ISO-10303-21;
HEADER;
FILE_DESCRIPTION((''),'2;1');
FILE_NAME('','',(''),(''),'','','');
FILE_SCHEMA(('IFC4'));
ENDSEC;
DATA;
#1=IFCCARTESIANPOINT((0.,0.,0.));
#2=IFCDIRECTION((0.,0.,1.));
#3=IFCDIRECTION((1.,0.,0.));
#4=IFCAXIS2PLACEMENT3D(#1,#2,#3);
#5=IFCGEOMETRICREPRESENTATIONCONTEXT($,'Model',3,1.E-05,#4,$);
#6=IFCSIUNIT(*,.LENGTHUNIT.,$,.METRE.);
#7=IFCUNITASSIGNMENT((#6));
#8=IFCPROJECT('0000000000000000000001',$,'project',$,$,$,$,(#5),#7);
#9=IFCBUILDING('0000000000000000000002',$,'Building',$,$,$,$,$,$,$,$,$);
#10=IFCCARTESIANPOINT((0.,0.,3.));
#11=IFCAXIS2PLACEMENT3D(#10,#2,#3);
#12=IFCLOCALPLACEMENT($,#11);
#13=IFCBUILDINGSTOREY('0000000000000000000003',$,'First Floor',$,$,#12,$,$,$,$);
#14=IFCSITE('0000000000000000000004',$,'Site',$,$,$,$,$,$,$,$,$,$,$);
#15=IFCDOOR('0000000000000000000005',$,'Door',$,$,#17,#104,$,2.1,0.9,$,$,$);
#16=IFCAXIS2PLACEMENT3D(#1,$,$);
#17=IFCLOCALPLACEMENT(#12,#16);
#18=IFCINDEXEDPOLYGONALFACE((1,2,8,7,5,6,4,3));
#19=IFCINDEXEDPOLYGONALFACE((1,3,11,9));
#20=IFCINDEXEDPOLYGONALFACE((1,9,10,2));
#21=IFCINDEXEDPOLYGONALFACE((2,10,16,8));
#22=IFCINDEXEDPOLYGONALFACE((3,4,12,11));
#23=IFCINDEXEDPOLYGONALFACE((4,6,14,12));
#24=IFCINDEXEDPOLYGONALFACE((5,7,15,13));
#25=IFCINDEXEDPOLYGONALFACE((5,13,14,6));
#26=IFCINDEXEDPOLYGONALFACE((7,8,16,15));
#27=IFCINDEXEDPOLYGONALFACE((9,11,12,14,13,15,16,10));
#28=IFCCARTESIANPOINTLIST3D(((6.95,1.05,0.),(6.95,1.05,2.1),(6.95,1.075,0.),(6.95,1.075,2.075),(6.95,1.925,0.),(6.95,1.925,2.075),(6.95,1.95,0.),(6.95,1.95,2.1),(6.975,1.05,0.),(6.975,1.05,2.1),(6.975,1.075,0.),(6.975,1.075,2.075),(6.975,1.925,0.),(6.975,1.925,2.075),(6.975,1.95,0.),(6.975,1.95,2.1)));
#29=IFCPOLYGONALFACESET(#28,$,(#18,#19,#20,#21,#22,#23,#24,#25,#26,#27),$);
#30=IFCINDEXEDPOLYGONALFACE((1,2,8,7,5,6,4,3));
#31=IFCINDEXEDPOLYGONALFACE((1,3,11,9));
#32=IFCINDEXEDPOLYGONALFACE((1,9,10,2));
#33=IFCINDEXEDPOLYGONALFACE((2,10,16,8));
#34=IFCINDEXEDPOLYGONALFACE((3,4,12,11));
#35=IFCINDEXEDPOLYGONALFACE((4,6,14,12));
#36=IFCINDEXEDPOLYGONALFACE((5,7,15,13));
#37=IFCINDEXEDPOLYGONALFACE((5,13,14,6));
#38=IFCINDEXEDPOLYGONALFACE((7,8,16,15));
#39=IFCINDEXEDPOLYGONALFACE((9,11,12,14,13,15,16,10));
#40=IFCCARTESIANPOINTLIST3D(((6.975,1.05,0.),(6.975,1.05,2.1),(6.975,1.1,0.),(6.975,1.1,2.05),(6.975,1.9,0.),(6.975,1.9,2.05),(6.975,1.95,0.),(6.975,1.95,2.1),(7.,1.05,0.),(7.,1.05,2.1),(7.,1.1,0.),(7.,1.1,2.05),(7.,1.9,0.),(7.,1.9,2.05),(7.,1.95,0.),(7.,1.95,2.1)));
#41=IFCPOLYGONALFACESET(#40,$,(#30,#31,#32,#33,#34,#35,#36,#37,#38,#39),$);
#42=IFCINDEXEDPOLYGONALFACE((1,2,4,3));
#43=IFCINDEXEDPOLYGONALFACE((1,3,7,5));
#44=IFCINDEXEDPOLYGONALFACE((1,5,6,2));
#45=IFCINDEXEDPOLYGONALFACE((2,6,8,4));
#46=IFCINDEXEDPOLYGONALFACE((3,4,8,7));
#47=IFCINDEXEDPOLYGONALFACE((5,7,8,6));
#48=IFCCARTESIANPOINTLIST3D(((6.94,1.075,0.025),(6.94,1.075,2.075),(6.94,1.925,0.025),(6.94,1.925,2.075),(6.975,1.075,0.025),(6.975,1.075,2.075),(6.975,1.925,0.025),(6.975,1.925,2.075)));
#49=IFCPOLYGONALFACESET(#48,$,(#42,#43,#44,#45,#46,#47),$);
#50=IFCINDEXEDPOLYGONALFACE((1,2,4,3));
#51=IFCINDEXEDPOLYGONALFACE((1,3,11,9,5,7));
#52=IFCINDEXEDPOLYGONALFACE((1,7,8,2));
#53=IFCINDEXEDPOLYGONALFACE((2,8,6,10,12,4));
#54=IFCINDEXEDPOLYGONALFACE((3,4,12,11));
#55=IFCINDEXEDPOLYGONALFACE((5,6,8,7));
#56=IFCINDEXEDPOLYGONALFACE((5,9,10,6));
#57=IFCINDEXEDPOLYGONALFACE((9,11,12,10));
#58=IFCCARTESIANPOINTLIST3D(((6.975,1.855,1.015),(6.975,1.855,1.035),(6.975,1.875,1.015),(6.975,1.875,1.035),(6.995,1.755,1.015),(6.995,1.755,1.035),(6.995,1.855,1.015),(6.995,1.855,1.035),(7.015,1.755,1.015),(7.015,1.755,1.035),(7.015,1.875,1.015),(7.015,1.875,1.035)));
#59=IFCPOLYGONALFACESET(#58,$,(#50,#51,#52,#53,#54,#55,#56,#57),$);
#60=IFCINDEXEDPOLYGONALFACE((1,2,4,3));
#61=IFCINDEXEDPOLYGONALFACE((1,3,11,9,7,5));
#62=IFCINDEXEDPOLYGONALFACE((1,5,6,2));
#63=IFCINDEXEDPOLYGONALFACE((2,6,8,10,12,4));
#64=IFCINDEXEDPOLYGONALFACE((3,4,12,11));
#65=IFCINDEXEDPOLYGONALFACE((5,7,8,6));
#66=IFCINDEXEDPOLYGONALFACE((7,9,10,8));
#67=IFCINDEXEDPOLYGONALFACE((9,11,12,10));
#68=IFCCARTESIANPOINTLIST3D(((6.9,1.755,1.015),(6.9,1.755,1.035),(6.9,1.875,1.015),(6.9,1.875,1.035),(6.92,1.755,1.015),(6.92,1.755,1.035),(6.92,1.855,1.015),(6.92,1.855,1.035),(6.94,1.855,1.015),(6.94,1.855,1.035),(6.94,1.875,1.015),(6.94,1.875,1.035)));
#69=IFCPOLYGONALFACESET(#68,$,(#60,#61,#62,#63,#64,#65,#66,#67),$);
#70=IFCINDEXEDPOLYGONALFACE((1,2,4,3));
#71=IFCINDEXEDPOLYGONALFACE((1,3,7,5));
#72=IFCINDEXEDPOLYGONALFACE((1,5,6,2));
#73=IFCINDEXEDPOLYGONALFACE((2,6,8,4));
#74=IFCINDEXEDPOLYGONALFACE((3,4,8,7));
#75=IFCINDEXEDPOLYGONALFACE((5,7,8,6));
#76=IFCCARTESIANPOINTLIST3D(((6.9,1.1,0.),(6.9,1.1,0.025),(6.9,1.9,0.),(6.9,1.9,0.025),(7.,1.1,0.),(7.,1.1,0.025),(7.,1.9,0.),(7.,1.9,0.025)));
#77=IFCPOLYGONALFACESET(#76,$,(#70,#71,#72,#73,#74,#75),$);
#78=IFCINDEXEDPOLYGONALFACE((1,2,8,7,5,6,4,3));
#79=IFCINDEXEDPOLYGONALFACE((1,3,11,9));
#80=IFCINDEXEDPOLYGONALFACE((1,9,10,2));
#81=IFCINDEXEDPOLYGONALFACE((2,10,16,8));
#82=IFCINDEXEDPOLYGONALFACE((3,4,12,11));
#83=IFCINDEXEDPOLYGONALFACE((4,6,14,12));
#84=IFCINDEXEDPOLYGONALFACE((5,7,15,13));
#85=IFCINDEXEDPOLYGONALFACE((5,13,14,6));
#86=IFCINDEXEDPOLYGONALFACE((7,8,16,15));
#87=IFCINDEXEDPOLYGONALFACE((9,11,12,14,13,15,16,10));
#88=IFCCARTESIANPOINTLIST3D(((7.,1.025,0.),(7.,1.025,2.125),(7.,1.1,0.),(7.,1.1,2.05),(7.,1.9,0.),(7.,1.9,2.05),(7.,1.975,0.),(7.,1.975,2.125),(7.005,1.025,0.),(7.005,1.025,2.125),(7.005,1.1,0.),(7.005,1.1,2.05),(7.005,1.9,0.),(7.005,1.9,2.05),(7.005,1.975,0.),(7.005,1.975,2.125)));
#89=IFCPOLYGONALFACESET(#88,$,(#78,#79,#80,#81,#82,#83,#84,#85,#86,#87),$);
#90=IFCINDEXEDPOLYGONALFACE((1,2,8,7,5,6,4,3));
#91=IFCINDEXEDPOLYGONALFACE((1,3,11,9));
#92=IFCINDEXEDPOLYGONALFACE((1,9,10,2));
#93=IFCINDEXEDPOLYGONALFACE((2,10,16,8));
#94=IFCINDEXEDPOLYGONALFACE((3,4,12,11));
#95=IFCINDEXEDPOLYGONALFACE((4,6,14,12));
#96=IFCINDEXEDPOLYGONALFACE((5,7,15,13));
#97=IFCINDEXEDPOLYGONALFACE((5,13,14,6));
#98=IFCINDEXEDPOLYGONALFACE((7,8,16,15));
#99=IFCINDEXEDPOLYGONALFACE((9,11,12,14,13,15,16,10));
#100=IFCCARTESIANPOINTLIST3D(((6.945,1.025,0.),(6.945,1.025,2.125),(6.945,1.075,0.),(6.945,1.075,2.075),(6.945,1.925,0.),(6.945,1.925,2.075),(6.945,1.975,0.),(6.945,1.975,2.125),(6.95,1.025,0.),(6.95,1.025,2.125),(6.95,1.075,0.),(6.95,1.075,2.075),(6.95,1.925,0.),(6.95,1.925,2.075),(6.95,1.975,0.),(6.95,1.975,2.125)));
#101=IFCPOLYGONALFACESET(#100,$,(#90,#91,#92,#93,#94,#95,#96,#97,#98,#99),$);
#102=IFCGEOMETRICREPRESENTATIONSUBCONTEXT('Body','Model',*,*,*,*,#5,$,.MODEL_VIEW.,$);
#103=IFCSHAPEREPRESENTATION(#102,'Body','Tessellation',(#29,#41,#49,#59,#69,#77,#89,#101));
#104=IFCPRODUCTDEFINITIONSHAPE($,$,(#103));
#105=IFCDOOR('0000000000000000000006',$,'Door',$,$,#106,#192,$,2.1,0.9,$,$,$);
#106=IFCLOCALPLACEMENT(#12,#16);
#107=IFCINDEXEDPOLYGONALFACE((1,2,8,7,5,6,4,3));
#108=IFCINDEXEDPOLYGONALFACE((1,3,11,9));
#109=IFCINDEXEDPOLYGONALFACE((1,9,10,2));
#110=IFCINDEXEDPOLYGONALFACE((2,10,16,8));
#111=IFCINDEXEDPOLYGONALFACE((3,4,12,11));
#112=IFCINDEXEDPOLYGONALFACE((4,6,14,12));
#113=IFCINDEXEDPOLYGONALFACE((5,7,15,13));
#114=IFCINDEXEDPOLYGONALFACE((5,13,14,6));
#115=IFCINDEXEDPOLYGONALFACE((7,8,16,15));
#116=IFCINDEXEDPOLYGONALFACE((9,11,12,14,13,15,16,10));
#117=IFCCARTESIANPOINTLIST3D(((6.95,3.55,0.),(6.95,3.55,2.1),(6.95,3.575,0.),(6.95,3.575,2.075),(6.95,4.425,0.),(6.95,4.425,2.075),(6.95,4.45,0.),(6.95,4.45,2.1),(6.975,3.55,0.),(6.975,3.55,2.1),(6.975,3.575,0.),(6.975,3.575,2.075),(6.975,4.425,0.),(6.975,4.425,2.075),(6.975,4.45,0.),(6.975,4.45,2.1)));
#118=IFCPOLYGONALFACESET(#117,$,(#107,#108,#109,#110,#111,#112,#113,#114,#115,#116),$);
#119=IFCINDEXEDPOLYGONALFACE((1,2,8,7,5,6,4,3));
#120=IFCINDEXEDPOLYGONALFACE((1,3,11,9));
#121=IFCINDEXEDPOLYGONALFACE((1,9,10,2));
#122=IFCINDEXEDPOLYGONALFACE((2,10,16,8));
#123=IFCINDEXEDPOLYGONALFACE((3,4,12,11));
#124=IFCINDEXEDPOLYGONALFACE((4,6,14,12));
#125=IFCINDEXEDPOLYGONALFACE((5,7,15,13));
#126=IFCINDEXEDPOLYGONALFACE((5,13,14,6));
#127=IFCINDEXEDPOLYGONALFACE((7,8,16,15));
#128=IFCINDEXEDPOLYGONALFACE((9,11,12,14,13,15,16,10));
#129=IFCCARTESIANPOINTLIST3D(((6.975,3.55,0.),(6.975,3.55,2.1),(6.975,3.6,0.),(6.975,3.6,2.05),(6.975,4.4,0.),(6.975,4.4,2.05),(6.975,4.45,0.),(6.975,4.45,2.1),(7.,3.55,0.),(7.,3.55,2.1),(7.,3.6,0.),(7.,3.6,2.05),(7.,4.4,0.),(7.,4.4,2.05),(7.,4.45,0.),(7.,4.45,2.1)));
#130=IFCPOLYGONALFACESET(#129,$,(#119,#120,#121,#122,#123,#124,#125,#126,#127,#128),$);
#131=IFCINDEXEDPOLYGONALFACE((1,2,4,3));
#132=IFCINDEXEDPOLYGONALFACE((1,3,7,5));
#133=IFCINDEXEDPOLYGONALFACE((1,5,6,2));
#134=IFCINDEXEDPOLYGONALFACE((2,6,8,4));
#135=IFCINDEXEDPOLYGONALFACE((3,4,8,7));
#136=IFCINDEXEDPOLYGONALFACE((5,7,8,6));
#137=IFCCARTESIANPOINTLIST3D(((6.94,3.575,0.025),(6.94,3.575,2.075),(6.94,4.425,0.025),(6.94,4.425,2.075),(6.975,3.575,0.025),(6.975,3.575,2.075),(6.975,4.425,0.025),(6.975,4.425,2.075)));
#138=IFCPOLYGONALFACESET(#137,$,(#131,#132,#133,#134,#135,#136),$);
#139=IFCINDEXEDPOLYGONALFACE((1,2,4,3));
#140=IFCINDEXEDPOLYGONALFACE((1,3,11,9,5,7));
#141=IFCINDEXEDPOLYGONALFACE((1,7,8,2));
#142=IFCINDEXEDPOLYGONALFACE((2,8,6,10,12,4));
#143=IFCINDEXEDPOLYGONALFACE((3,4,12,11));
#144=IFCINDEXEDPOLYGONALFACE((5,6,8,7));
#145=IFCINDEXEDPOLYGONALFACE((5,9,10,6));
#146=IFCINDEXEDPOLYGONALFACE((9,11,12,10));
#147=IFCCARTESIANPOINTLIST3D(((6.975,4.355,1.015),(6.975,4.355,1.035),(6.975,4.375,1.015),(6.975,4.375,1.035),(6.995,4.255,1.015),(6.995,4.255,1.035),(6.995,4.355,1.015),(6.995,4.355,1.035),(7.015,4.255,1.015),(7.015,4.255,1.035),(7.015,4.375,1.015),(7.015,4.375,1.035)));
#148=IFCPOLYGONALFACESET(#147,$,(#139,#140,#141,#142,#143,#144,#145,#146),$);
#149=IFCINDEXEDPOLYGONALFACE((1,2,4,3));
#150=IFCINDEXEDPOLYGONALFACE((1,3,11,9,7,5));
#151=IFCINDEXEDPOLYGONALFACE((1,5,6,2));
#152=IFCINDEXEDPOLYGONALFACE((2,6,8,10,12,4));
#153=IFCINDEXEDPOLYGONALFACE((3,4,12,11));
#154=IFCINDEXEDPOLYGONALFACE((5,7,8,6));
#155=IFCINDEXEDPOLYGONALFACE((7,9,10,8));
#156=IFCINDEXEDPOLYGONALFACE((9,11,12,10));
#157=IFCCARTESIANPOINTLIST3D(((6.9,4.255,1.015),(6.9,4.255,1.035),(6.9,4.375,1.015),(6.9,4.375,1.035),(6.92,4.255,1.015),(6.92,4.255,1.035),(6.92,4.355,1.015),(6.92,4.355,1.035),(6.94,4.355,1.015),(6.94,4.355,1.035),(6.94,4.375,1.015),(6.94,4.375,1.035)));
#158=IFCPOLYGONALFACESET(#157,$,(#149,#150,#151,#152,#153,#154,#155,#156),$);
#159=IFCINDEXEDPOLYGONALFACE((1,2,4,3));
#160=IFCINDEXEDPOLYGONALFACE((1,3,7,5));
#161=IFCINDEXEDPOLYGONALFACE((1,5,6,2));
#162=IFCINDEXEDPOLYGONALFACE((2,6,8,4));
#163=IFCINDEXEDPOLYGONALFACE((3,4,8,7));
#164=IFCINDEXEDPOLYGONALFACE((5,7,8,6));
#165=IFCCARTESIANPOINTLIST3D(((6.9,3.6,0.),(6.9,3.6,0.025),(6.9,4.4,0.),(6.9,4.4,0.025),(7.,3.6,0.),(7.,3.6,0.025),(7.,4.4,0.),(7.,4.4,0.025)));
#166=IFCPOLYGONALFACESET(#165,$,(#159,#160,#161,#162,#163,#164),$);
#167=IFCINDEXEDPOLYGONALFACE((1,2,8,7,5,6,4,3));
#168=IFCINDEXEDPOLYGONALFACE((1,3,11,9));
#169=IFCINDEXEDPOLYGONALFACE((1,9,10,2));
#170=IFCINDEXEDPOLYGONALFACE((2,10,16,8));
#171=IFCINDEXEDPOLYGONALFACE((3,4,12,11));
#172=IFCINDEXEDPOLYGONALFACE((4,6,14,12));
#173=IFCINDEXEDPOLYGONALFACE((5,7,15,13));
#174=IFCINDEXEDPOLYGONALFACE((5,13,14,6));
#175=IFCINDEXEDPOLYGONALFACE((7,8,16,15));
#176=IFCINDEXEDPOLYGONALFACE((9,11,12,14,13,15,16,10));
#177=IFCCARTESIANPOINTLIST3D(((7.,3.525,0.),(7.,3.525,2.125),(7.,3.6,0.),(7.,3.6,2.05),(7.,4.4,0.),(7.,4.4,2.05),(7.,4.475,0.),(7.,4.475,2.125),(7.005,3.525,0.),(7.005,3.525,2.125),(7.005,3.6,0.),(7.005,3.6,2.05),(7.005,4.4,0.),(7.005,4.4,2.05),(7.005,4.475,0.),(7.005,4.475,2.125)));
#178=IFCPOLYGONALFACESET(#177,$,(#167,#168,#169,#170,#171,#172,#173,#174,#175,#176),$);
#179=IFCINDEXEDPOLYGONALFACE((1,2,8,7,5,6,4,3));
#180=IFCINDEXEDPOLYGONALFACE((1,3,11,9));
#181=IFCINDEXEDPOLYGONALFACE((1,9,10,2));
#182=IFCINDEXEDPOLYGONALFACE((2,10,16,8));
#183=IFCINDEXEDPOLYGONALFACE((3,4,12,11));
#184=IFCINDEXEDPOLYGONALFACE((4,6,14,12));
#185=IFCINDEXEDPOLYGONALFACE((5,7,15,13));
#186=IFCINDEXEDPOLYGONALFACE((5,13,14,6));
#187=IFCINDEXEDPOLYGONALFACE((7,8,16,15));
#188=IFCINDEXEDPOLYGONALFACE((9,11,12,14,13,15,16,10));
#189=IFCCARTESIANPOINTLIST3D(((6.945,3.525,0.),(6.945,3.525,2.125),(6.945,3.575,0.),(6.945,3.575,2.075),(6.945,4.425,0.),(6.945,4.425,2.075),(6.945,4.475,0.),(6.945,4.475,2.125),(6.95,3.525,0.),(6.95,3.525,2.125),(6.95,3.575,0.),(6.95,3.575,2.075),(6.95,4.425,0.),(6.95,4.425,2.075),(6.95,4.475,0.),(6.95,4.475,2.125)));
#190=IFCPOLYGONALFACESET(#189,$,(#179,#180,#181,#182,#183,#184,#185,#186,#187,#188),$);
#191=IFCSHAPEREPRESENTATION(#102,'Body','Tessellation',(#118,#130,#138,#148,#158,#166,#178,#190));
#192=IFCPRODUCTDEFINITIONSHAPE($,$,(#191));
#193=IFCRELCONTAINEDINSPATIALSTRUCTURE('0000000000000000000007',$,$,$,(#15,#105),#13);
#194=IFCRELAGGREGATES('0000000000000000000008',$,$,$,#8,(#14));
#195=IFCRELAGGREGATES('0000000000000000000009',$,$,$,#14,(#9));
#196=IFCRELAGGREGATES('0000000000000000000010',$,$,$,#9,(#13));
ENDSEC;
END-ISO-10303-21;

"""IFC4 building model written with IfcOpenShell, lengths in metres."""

from ifc_helpers import new_model, si_unit, frame, origin_with_axes, place, context, subcontext, project, spatial, line, indexed_curve, outline, extrude, element, save


model = new_model("IFC4")

# Units and contexts
model_context = context("Model", 3, precision=1e-05, world=origin_with_axes())
body_context = subcontext(model_context, "Body", "Model", "MODEL_VIEW")
ifc_project = project(units=[si_unit("LENGTHUNIT", "METRE")], contexts=[model_context])

# Site, building, storey
site = spatial("IfcSite", under=ifc_project, Name="Site")
building = spatial("IfcBuilding", under=site, Name="Building")
storey_placement = place(None, frame((0.0, 0.0, 3.0), z_axis=(0.0, 0.0, 1.0), x_axis=(1.0, 0.0, 0.0)))
storey = spatial("IfcBuildingStorey", under=building, at=storey_placement, Name="First Floor")

# Doors
door_1_placement = place(storey_placement, frame((7.0, 1.05, 0.0), z_axis=(0.0, 0.0, 1.0), x_axis=(0.0, 1.0, 0.0)))
element("IfcDoor", 1, at=door_1_placement, inside=storey, Name="Door", OverallHeight=2.1, OverallWidth=0.9, context=body_context, shape_type="SweptSolid", body=[
    extrude(outline(indexed_curve([(0.0, 0.0), (0.0, 2.1), (0.9, 2.1), (0.9, 0.0), (0.875, 0.0), (0.875, 2.075), (0.025, 2.075), (0.025, 0.0)], segments=[line(1, 2, 3, 4, 5, 6, 7, 8, 1)])), frame((0.0, 0.025, 0.0), z_axis=(0.0, -1.0, 0.0), x_axis=(1.0, 0.0, 0.0)), (0.0, 0.0, -1.0), 0.025),
    extrude(outline(indexed_curve([(0.0, 0.0), (0.0, 2.1), (0.9, 2.1), (0.9, 0.0), (0.85, 0.0), (0.85, 2.05), (0.05, 2.05), (0.05, 0.0)], segments=[line(1, 2, 3, 4, 5, 6, 7, 8, 1)])), frame((0.0, 0.0, 0.0), z_axis=(0.0, -1.0, 0.0), x_axis=(1.0, 0.0, 0.0)), (0.0, 0.0, -1.0), 0.025),
    extrude(outline(indexed_curve([(0.0, 0.0), (0.85, 0.0), (0.85, 0.035), (0.0, 0.035)], segments=[line(1, 2, 3, 4, 1)])), frame((0.025, 0.025, 0.025), z_axis=(0.0, 0.0, 1.0), x_axis=(1.0, 0.0, 0.0)), (0.0, 0.0, 1.0), 2.05),
    extrude(outline(indexed_curve([(0.0, 0.0), (0.0, -0.04), (-0.12, -0.04), (-0.12, -0.02), (-0.02, -0.02), (-0.02, 0.0)], segments=[line(1, 2, 3, 4, 5, 6, 1)])), frame((0.825, 0.025, 1.015), z_axis=(0.0, 0.0, 1.0), x_axis=(1.0, 0.0, 0.0)), (0.0, 0.0, 1.0), 0.02),
    extrude(outline(indexed_curve([(0.0, 0.0), (0.0, 0.04), (-0.12, 0.04), (-0.12, 0.02), (-0.02, 0.02), (-0.02, 0.0)], segments=[line(1, 2, 3, 4, 5, 6, 1)])), frame((0.825, 0.06, 1.015), z_axis=(0.0, 0.0, 1.0), x_axis=(1.0, 0.0, 0.0)), (0.0, 0.0, 1.0), 0.02),
    extrude(outline(indexed_curve([(0.0, 0.0), (0.8, 0.0), (0.8, 0.1), (0.0, 0.1)], segments=[line(1, 2, 3, 4, 1)])), frame((0.05, 0.0, 0.0), z_axis=(0.0, 0.0, 1.0), x_axis=(1.0, 0.0, 0.0)), (0.0, 0.0, 1.0), 0.025),
    extrude(outline(indexed_curve([(0.0, 0.0), (0.0, 2.125), (0.95, 2.125), (0.95, 0.0), (0.875, 0.0), (0.875, 2.05), (0.075, 2.05), (0.075, 0.0)], segments=[line(1, 2, 3, 4, 5, 6, 7, 8, 1)])), frame((-0.025, -0.005, 0.0), z_axis=(0.0, -1.0, 0.0), x_axis=(1.0, 0.0, 0.0)), (0.0, 0.0, -1.0), 0.005),
    extrude(outline(indexed_curve([(0.0, 0.0), (0.0, 2.125), (0.95, 2.125), (0.95, 0.0), (0.9, 0.0), (0.9, 2.075), (0.05, 2.075), (0.05, 0.0)], segments=[line(1, 2, 3, 4, 5, 6, 7, 8, 1)])), frame((-0.025, 0.05, 0.0), z_axis=(0.0, -1.0, 0.0), x_axis=(1.0, 0.0, 0.0)), (0.0, 0.0, -1.0), 0.005),
])
door_2_placement = place(storey_placement, frame((7.0, 3.55, 0.0), z_axis=(0.0, 0.0, 1.0), x_axis=(0.0, 1.0, 0.0)))
element("IfcDoor", 2, at=door_2_placement, inside=storey, Name="Door", OverallHeight=2.1, OverallWidth=0.9, context=body_context, shape_type="SweptSolid", body=[
    extrude(outline(indexed_curve([(0.0, 0.0), (0.0, 2.1), (0.9, 2.1), (0.9, 0.0), (0.875, 0.0), (0.875, 2.075), (0.025, 2.075), (0.025, 0.0)], segments=[line(1, 2, 3, 4, 5, 6, 7, 8, 1)])), frame((0.0, 0.025, 0.0), z_axis=(0.0, -1.0, 0.0), x_axis=(1.0, 0.0, 0.0)), (0.0, 0.0, -1.0), 0.025),
    extrude(outline(indexed_curve([(0.0, 0.0), (0.0, 2.1), (0.9, 2.1), (0.9, 0.0), (0.85, 0.0), (0.85, 2.05), (0.05, 2.05), (0.05, 0.0)], segments=[line(1, 2, 3, 4, 5, 6, 7, 8, 1)])), frame((0.0, 0.0, 0.0), z_axis=(0.0, -1.0, 0.0), x_axis=(1.0, 0.0, 0.0)), (0.0, 0.0, -1.0), 0.025),
    extrude(outline(indexed_curve([(0.0, 0.0), (0.85, 0.0), (0.85, 0.035), (0.0, 0.035)], segments=[line(1, 2, 3, 4, 1)])), frame((0.025, 0.025, 0.025), z_axis=(0.0, 0.0, 1.0), x_axis=(1.0, 0.0, 0.0)), (0.0, 0.0, 1.0), 2.05),
    extrude(outline(indexed_curve([(0.0, 0.0), (0.0, -0.04), (-0.12, -0.04), (-0.12, -0.02), (-0.02, -0.02), (-0.02, 0.0)], segments=[line(1, 2, 3, 4, 5, 6, 1)])), frame((0.825, 0.025, 1.015), z_axis=(0.0, 0.0, 1.0), x_axis=(1.0, 0.0, 0.0)), (0.0, 0.0, 1.0), 0.02),
    extrude(outline(indexed_curve([(0.0, 0.0), (0.0, 0.04), (-0.12, 0.04), (-0.12, 0.02), (-0.02, 0.02), (-0.02, 0.0)], segments=[line(1, 2, 3, 4, 5, 6, 1)])), frame((0.825, 0.06, 1.015), z_axis=(0.0, 0.0, 1.0), x_axis=(1.0, 0.0, 0.0)), (0.0, 0.0, 1.0), 0.02),
    extrude(outline(indexed_curve([(0.0, 0.0), (0.8, 0.0), (0.8, 0.1), (0.0, 0.1)], segments=[line(1, 2, 3, 4, 1)])), frame((0.05, 0.0, 0.0), z_axis=(0.0, 0.0, 1.0), x_axis=(1.0, 0.0, 0.0)), (0.0, 0.0, 1.0), 0.025),
    extrude(outline(indexed_curve([(0.0, 0.0), (0.0, 2.125), (0.95, 2.125), (0.95, 0.0), (0.875, 0.0), (0.875, 2.05), (0.075, 2.05), (0.075, 0.0)], segments=[line(1, 2, 3, 4, 5, 6, 7, 8, 1)])), frame((-0.025, -0.005, 0.0), z_axis=(0.0, -1.0, 0.0), x_axis=(1.0, 0.0, 0.0)), (0.0, 0.0, -1.0), 0.005),
    extrude(outline(indexed_curve([(0.0, 0.0), (0.0, 2.125), (0.95, 2.125), (0.95, 0.0), (0.9, 0.0), (0.9, 2.075), (0.05, 2.075), (0.05, 0.0)], segments=[line(1, 2, 3, 4, 5, 6, 7, 8, 1)])), frame((-0.025, 0.05, 0.0), z_axis=(0.0, -1.0, 0.0), x_axis=(1.0, 0.0, 0.0)), (0.0, 0.0, -1.0), 0.005),
])

save(model, "model.ifc")
